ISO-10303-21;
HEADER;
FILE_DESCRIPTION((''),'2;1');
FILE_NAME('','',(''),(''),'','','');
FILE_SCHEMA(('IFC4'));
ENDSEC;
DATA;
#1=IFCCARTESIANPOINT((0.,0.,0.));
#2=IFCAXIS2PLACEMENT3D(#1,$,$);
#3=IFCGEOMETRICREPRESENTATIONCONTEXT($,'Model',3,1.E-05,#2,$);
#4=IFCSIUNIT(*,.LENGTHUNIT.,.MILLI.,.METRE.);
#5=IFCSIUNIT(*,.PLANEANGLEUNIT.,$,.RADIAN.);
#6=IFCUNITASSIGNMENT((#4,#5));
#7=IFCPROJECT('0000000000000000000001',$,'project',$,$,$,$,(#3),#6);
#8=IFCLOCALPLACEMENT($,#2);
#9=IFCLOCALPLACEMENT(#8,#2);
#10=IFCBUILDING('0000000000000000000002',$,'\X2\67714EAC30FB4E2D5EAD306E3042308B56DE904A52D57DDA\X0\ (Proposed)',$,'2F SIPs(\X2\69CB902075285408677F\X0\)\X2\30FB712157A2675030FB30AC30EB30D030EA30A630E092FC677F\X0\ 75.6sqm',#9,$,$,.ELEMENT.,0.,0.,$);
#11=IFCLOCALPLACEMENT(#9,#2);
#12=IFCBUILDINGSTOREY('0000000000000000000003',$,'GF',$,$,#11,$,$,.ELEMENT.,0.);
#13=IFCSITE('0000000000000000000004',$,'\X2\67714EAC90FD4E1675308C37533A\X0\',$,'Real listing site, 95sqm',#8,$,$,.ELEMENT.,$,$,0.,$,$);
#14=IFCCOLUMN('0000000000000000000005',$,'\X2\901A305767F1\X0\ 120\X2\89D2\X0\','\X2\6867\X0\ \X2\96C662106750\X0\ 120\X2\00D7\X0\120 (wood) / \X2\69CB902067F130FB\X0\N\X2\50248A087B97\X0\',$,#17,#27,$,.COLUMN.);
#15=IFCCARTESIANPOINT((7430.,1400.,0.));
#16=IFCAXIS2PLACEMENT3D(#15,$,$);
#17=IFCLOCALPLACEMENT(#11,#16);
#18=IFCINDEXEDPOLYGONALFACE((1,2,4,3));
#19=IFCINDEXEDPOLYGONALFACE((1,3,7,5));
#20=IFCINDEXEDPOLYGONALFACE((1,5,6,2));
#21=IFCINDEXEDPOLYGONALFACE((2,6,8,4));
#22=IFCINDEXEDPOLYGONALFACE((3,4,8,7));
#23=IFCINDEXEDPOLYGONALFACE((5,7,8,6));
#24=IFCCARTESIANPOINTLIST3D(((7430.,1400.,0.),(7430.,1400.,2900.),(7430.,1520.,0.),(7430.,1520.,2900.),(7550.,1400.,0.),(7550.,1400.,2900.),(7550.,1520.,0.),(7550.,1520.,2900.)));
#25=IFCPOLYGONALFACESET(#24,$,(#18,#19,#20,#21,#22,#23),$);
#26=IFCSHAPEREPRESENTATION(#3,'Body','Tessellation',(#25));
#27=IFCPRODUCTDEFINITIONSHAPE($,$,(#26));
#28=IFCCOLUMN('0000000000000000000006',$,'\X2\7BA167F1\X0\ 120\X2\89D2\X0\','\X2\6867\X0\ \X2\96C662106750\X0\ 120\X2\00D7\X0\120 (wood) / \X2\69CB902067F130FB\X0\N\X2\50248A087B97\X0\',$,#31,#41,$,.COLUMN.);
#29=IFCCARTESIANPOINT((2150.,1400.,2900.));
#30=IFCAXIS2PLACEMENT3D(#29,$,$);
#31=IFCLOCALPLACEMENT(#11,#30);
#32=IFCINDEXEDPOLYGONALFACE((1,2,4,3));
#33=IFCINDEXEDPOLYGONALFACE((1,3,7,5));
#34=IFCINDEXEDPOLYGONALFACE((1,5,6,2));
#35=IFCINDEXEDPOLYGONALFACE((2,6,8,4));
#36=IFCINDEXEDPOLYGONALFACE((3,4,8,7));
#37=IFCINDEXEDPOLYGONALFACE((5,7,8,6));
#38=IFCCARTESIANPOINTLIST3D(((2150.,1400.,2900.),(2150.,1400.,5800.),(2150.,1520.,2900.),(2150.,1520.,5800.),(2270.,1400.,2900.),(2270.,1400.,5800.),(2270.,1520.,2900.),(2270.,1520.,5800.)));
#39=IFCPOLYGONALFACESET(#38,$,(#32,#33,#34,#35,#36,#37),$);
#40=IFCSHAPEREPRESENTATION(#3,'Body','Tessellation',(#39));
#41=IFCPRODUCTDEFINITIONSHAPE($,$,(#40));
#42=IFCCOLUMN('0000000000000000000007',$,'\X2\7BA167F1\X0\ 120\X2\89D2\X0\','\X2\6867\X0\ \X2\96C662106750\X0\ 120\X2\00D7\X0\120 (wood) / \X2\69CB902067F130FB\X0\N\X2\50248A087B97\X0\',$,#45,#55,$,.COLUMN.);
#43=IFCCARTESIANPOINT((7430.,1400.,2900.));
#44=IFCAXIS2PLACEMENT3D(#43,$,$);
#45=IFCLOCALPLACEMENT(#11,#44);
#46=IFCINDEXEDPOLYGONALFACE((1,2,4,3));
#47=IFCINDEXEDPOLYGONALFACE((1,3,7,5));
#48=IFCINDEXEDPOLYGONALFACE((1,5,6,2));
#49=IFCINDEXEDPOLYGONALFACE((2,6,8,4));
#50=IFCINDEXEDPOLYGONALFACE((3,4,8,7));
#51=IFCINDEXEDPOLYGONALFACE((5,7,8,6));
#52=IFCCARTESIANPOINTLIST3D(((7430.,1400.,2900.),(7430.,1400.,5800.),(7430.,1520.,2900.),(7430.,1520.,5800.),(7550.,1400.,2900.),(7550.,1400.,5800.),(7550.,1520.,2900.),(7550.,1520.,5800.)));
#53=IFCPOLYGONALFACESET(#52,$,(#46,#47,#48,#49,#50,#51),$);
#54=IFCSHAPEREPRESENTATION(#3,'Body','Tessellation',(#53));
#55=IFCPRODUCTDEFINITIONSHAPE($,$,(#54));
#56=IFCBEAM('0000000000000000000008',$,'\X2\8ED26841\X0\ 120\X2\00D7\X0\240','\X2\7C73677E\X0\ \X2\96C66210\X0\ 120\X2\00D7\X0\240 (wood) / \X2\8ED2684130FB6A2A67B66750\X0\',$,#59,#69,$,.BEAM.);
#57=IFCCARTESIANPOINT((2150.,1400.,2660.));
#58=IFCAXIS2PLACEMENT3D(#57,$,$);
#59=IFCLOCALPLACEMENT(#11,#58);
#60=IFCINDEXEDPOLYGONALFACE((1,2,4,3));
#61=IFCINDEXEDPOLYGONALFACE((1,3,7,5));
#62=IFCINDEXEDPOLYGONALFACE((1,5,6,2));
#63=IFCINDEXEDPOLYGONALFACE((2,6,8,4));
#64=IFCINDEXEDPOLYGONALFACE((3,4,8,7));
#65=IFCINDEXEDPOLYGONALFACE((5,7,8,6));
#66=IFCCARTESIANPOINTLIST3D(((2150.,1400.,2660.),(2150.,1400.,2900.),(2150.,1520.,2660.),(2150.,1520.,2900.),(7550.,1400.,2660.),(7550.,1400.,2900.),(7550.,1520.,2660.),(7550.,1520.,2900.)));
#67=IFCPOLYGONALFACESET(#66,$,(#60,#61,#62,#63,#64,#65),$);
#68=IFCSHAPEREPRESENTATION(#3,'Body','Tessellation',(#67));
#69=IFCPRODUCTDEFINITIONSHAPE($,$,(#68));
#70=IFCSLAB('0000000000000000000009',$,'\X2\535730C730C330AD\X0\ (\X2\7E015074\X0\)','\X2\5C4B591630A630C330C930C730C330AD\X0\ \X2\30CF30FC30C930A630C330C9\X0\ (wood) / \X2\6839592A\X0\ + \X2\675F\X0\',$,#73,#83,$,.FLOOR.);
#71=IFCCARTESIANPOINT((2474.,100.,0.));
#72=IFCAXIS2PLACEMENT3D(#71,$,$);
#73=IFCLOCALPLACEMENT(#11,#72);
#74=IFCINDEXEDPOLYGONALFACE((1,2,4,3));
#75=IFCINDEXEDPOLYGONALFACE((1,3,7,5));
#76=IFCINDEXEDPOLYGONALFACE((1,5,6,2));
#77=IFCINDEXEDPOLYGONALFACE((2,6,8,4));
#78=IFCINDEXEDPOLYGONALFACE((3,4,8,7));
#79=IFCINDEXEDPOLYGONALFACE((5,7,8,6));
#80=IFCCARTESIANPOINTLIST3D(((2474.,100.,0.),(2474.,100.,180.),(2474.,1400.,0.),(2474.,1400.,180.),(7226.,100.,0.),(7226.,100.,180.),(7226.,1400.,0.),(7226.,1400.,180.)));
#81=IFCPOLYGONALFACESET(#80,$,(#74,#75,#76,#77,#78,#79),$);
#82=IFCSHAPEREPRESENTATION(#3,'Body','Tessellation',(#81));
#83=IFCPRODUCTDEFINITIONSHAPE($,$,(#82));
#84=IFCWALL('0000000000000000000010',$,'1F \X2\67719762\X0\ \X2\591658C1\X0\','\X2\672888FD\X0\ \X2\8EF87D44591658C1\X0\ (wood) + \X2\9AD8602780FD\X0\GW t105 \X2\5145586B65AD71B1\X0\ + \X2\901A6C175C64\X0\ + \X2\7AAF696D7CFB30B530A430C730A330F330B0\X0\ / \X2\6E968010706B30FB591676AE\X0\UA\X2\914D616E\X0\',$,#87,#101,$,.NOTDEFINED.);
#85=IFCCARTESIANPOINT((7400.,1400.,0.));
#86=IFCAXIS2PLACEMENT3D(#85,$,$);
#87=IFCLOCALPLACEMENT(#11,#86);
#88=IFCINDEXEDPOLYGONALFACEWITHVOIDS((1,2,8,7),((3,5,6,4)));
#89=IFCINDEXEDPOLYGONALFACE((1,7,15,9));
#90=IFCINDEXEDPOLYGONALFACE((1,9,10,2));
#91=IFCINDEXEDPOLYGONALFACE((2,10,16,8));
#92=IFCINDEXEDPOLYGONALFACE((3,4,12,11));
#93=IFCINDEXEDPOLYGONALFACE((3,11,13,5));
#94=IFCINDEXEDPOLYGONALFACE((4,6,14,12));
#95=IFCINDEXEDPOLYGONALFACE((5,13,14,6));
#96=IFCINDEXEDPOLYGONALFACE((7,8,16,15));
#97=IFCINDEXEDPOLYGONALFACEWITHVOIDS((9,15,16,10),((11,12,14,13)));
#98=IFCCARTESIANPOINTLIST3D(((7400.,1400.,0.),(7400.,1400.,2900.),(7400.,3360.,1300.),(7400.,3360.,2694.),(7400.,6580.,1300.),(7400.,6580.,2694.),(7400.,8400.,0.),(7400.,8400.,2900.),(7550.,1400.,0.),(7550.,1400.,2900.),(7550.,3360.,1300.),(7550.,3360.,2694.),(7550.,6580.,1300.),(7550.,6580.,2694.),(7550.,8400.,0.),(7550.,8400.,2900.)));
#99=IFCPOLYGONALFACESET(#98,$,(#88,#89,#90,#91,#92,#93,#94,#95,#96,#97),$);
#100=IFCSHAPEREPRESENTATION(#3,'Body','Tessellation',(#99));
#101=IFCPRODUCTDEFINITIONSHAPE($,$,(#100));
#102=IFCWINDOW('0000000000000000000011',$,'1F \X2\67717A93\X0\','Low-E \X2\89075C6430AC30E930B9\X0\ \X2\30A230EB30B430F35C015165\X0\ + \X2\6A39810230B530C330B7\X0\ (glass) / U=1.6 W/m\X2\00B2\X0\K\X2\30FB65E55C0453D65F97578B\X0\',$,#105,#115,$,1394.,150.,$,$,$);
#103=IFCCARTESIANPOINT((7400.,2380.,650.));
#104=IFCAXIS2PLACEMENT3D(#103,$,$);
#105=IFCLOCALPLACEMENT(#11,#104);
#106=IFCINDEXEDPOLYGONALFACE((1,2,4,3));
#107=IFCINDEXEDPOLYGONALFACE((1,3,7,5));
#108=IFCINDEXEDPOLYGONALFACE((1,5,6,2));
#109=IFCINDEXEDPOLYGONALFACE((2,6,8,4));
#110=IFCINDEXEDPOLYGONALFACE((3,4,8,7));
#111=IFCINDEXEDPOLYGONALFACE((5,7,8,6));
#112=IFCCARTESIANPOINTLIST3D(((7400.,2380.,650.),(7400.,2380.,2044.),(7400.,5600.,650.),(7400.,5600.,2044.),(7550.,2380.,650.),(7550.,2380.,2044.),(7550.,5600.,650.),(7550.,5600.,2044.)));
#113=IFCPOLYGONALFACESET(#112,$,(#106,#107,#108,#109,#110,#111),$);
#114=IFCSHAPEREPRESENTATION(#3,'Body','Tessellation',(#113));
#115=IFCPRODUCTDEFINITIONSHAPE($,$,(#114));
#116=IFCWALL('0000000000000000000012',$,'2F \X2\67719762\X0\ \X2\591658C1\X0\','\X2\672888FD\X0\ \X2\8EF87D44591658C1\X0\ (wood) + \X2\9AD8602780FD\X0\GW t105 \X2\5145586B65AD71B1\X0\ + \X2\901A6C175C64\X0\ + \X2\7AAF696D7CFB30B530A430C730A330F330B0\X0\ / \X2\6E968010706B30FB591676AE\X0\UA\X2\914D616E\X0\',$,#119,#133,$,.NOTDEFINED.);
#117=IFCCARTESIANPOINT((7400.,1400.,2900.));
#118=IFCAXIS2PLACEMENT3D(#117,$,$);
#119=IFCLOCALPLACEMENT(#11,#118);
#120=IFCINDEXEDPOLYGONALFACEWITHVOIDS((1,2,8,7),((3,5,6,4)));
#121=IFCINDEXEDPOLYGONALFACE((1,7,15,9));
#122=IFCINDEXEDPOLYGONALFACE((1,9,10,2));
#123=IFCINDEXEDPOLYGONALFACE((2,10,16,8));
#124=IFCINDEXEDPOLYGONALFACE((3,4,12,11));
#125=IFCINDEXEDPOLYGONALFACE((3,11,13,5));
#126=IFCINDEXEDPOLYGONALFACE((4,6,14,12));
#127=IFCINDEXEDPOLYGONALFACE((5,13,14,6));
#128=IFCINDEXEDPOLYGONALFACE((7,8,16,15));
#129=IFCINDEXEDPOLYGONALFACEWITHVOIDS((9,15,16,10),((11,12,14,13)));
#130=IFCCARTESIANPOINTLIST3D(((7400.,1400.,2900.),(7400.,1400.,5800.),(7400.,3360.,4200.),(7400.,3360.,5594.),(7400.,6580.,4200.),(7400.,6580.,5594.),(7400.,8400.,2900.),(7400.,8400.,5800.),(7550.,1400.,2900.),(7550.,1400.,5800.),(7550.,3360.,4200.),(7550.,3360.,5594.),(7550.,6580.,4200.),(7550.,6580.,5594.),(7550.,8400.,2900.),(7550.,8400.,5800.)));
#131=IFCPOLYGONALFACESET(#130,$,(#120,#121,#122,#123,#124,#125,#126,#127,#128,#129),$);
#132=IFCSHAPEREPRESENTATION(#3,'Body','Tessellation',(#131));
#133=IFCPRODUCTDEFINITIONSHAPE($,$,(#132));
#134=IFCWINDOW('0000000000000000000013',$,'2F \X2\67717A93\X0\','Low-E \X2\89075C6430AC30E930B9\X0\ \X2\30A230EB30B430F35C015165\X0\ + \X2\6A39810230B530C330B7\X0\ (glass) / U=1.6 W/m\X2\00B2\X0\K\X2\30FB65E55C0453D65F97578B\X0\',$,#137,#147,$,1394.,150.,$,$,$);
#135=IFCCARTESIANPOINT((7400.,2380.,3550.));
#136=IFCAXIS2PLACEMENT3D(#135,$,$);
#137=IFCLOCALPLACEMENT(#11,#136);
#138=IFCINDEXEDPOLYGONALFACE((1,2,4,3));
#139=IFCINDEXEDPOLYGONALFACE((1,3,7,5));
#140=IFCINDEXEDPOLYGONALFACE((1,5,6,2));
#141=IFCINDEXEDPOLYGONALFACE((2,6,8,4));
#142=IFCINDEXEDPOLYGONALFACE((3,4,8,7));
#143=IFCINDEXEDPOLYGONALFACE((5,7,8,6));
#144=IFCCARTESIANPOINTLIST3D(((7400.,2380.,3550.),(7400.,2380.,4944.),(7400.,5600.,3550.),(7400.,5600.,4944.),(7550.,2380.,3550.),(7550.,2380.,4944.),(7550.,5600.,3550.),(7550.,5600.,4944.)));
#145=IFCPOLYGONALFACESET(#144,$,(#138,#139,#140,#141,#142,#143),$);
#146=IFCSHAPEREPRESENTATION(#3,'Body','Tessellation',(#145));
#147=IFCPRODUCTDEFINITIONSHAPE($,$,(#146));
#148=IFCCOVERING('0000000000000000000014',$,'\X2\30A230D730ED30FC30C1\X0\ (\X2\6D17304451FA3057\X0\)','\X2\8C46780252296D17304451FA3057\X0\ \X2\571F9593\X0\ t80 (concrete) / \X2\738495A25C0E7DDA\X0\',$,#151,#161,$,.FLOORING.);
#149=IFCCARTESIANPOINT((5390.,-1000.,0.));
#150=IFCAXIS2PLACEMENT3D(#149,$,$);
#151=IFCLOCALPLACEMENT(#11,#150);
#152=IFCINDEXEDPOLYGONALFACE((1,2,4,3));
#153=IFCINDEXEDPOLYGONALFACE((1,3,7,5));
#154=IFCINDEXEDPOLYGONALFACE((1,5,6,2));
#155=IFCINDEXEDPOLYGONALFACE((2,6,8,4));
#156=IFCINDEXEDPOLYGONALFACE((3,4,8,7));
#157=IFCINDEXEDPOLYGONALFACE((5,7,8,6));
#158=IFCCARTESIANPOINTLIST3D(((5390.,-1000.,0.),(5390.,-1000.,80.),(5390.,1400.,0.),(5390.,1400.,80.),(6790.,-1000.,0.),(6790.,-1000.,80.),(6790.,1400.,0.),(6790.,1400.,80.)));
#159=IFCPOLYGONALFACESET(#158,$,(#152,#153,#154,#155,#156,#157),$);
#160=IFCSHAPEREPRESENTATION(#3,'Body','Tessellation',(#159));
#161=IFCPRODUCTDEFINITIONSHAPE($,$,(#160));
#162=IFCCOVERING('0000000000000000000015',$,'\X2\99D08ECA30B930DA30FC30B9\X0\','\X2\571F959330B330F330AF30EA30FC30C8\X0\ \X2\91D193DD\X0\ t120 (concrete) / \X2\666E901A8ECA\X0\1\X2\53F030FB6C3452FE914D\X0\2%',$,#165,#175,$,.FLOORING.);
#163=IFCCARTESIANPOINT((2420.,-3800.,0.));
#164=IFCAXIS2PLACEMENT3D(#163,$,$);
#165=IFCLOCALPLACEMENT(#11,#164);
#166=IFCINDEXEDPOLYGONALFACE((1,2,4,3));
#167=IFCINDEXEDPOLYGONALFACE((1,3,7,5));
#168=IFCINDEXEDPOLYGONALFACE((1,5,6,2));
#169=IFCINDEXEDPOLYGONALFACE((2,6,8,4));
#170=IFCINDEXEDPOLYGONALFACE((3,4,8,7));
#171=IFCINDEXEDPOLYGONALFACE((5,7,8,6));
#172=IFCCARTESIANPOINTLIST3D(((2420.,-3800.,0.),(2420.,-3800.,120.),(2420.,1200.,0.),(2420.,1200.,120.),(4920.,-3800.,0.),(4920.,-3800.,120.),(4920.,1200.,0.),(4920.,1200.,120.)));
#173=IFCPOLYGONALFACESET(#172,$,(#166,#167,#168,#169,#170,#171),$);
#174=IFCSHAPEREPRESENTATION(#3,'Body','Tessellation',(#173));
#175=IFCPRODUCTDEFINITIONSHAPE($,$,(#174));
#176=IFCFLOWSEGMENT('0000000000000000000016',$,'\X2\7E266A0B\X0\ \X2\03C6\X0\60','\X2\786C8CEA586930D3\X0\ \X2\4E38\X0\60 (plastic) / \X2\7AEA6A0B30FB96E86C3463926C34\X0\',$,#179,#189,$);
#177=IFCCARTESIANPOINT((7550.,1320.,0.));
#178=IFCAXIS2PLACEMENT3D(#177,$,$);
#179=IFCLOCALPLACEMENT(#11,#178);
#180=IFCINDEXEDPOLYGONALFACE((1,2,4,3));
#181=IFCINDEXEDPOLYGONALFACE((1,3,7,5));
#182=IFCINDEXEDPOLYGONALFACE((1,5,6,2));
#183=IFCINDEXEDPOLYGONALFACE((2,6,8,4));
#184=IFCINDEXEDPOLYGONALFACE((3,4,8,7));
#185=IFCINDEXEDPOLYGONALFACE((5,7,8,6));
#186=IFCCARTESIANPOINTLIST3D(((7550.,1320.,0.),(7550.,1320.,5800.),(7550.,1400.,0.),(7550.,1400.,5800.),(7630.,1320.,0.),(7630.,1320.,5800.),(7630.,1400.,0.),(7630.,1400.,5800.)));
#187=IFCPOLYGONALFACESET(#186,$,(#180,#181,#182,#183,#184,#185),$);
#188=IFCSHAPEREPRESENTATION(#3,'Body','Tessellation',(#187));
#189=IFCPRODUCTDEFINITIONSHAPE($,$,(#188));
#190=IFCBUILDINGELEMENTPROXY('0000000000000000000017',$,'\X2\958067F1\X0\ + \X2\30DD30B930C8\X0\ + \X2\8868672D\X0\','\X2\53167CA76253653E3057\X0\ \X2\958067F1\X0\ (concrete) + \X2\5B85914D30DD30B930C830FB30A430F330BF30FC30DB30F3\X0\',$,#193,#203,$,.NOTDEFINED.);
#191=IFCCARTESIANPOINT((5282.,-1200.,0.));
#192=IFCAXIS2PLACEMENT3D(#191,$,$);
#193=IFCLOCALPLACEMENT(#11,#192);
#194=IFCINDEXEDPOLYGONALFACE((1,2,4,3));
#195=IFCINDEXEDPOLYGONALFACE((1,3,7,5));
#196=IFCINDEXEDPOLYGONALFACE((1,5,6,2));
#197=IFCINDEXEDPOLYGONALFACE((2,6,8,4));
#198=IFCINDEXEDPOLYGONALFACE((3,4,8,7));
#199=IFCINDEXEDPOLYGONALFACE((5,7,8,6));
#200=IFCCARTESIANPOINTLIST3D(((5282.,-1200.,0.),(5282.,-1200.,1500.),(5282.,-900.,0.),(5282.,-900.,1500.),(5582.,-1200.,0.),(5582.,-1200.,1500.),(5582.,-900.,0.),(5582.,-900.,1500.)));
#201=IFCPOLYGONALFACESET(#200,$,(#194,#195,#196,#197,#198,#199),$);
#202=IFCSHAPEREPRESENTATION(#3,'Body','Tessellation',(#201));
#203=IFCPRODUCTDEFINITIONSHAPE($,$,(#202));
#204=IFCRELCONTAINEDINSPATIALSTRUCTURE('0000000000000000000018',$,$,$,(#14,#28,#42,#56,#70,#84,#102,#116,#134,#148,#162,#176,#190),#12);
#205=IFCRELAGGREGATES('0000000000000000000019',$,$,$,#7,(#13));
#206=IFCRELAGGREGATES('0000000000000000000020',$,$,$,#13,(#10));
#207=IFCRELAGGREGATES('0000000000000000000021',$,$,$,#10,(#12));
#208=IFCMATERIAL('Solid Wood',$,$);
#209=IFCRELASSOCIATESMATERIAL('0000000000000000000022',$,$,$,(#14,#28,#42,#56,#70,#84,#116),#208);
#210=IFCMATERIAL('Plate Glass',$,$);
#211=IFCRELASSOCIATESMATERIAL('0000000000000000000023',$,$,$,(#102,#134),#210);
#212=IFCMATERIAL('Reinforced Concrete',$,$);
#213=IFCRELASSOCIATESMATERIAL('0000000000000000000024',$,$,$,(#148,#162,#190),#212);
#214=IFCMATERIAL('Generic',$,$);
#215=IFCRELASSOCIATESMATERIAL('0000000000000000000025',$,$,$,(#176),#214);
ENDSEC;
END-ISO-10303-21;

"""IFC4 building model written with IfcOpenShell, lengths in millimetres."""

from ifc_helpers import new_model, si_unit, frame, frame_2d, origin, place, context, project, spatial, rectangle, extrude, material, element, fill, save


model = new_model("IFC4")

# Units and contexts
model_context = context("Model", 3, precision=1e-05, world=origin())
ifc_project = project(units=[si_unit("LENGTHUNIT", "METRE", prefix="MILLI"), si_unit("PLANEANGLEUNIT", "RADIAN")], contexts=[model_context])

# Site, building, storey
site_placement = place(None, origin())
site = spatial("IfcSite", under=ifc_project, at=site_placement, Name="東京都世田谷区", ObjectType="Real listing site, 95sqm", CompositionType="ELEMENT", RefElevation=0.0)
building_placement = place(site_placement, origin())
building = spatial("IfcBuilding", under=site, at=building_placement, Name="東京・中庭のある回遊動線 (Proposed)", ObjectType="2F SIPs(構造用合板)・無垢材・ガルバリウム鋼板 75.6sqm", CompositionType="ELEMENT", ElevationOfRefHeight=0.0, ElevationOfTerrain=0.0)
storey_placement = place(building_placement, origin())
storey = spatial("IfcBuildingStorey", under=building, at=storey_placement, Name="GF", CompositionType="ELEMENT", Elevation=0.0)

# Columns
ifc_material_1 = material(Name="Solid Wood")
column_1_placement = place(storey_placement, frame((7430.0, 1400.0, 0.0)))
element("IfcColumn", 1, at=column_1_placement, inside=storey, material=ifc_material_1, Name="通し柱 120角", Description="桧 集成材 120×120 (wood) / 構造柱・N値計算", PredefinedType="COLUMN", context=model_context, shape_type="SweptSolid", body=[
    extrude(rectangle(XDim=120.0, YDim=120.0, at=frame_2d((60.0, 60.0))), frame((7430.0, 1400.0, 0.0)), (0.0, 0.0, 1.0), 2900.0),
])
column_2_placement = place(storey_placement, frame((2150.0, 1400.0, 2900.0)))
element("IfcColumn", 2, at=column_2_placement, inside=storey, material=ifc_material_1, Name="管柱 120角", Description="桧 集成材 120×120 (wood) / 構造柱・N値計算", PredefinedType="COLUMN", context=model_context, shape_type="SweptSolid", body=[
    extrude(rectangle(XDim=120.0, YDim=120.0, at=frame_2d((60.0, 60.0))), frame((2150.0, 1400.0, 2900.0)), (0.0, 0.0, 1.0), 2900.0),
])
column_3_placement = place(storey_placement, frame((7430.0, 1400.0, 2900.0)))
element("IfcColumn", 3, at=column_3_placement, inside=storey, material=ifc_material_1, Name="管柱 120角", Description="桧 集成材 120×120 (wood) / 構造柱・N値計算", PredefinedType="COLUMN", context=model_context, shape_type="SweptSolid", body=[
    extrude(rectangle(XDim=120.0, YDim=120.0, at=frame_2d((60.0, 60.0))), frame((7430.0, 1400.0, 2900.0)), (0.0, 0.0, 1.0), 2900.0),
])

# Beam
beam_1_placement = place(storey_placement, frame((2150.0, 1400.0, 2660.0)))
element("IfcBeam", 4, at=beam_1_placement, inside=storey, material=ifc_material_1, Name="軒桁 120×240", Description="米松 集成 120×240 (wood) / 軒桁・横架材", PredefinedType="BEAM", context=model_context, shape_type="SweptSolid", body=[
    extrude(rectangle(XDim=5400.0, YDim=120.0, at=frame_2d((2700.0, 60.0))), frame((2150.0, 1400.0, 2660.0)), (0.0, 0.0, 1.0), 240.0),
])

# Slab
slab_placement = place(storey_placement, frame((2474.0, 100.0, 0.0)))
element("IfcSlab", 5, at=slab_placement, inside=storey, material=ifc_material_1, Name="南デッキ (縁側)", Description="屋外ウッドデッキ ハードウッド (wood) / 根太 + 束", PredefinedType="FLOOR", context=model_context, shape_type="SweptSolid", body=[
    extrude(rectangle(XDim=4752.0, YDim=1300.0, at=frame_2d((2376.0, 650.0))), frame((2474.0, 100.0, 0.0)), (0.0, 0.0, 1.0), 180.0),
])

# Walls, openings, windows
wall_1_placement = place(storey_placement, frame((7400.0, 1400.0, 0.0)))
wall_1 = element("IfcWall", 6, at=wall_1_placement, inside=storey, material=ifc_material_1, Name="1F 東面 外壁", Description="木製 軸組外壁 (wood) + 高性能GW t105 充填断熱 + 通気層 + 窯業系サイディング / 準耐火・外皮UA配慮", PredefinedType="NOTDEFINED", context=model_context, shape_type="SweptSolid", body=[
    extrude(rectangle(XDim=150.0, YDim=7000.0, at=frame_2d((75.0, 3500.0))), frame((7400.0, 1400.0, 0.0)), (0.0, 0.0, 1.0), 2900.0),
])
opening_1_placement = place(storey_placement, frame((7400.0, 2380.0, 650.0)))
opening_1 = element("IfcOpeningElement", 7, at=opening_1_placement, cuts=wall_1, PredefinedType="NOTDEFINED", context=model_context, shape_type="SweptSolid", body=[
    extrude(rectangle(XDim=150.0, YDim=3220.0, at=frame_2d((75.0, 1610.0))), frame((7400.0, 2380.0, 650.0)), (0.0, 0.0, 1.0), 1394.0),
])
ifc_material_2 = material(Name="Plate Glass")
window_1_placement = place(storey_placement, frame((7400.0, 2380.0, 650.0)))
window_1 = element("IfcWindow", 8, at=window_1_placement, inside=storey, material=ifc_material_2, Name="1F 東窓", Description="Low-E 複層ガラス アルゴン封入 + 樹脂サッシ (glass) / U=1.6 W/m²K・日射取得型", OverallHeight=1394.0, OverallWidth=150.0, context=model_context, shape_type="SweptSolid", body=[
    extrude(rectangle(XDim=150.0, YDim=3220.0, at=frame_2d((75.0, 1610.0))), frame((7400.0, 2380.0, 650.0)), (0.0, 0.0, 1.0), 1394.0),
])
fill(opening_1, window_1)
wall_2_placement = place(storey_placement, frame((7400.0, 1400.0, 2900.0)))
wall_2 = element("IfcWall", 9, at=wall_2_placement, inside=storey, material=ifc_material_1, Name="2F 東面 外壁", Description="木製 軸組外壁 (wood) + 高性能GW t105 充填断熱 + 通気層 + 窯業系サイディング / 準耐火・外皮UA配慮", PredefinedType="NOTDEFINED", context=model_context, shape_type="SweptSolid", body=[
    extrude(rectangle(XDim=150.0, YDim=7000.0, at=frame_2d((75.0, 3500.0))), frame((7400.0, 1400.0, 2900.0)), (0.0, 0.0, 1.0), 2900.0),
])
opening_2_placement = place(storey_placement, frame((7400.0, 2380.0, 3550.0)))
opening_2 = element("IfcOpeningElement", 10, at=opening_2_placement, cuts=wall_2, PredefinedType="NOTDEFINED", context=model_context, shape_type="SweptSolid", body=[
    extrude(rectangle(XDim=150.0, YDim=3220.0, at=frame_2d((75.0, 1610.0))), frame((7400.0, 2380.0, 3550.0)), (0.0, 0.0, 1.0), 1394.0),
])
window_2_placement = place(storey_placement, frame((7400.0, 2380.0, 3550.0)))
window_2 = element("IfcWindow", 11, at=window_2_placement, inside=storey, material=ifc_material_2, Name="2F 東窓", Description="Low-E 複層ガラス アルゴン封入 + 樹脂サッシ (glass) / U=1.6 W/m²K・日射取得型", OverallHeight=1394.0, OverallWidth=150.0, context=model_context, shape_type="SweptSolid", body=[
    extrude(rectangle(XDim=150.0, YDim=3220.0, at=frame_2d((75.0, 1610.0))), frame((7400.0, 2380.0, 3550.0)), (0.0, 0.0, 1.0), 1394.0),
])
fill(opening_2, window_2)

# Coverings
ifc_material_3 = material(Name="Reinforced Concrete")
covering_1_placement = place(storey_placement, frame((5390.0, -1000.0, 0.0)))
element("IfcCovering", 12, at=covering_1_placement, inside=storey, material=ifc_material_3, Name="アプローチ (洗い出し)", Description="豆砂利洗い出し 土間 t80 (concrete) / 玄関導線", PredefinedType="FLOORING", context=model_context, shape_type="SweptSolid", body=[
    extrude(rectangle(XDim=1400.0, YDim=2400.0, at=frame_2d((700.0, 1200.0))), frame((5390.0, -1000.0, 0.0)), (0.0, 0.0, 1.0), 80.0),
])
covering_2_placement = place(storey_placement, frame((2420.0, -3800.0, 0.0)))
element("IfcCovering", 13, at=covering_2_placement, inside=storey, material=ifc_material_3, Name="駐車スペース", Description="土間コンクリート 金鏝 t120 (concrete) / 普通車1台・水勾配2%", PredefinedType="FLOORING", context=model_context, shape_type="SweptSolid", body=[
    extrude(rectangle(XDim=2500.0, YDim=5000.0, at=frame_2d((1250.0, 2500.0))), frame((2420.0, -3800.0, 0.0)), (0.0, 0.0, 1.0), 120.0),
])

# Flow segment
ifc_material_4 = material(Name="Generic")
flow_segment_placement = place(storey_placement, frame((7550.0, 1320.0, 0.0)))
element("IfcFlowSegment", 14, at=flow_segment_placement, inside=storey, material=ifc_material_4, Name="縦樋 φ60", Description="硬質塩ビ 丸60 (plastic) / 竪樋・雨水排水", context=model_context, shape_type="SweptSolid", body=[
    extrude(rectangle(XDim=80.0, YDim=80.0, at=frame_2d((40.0, 40.0))), frame((7550.0, 1320.0, 0.0)), (0.0, 0.0, 1.0), 5800.0),
])

# Building element proxy
proxy_placement = place(storey_placement, frame((5282.0, -1200.0, 0.0)))
element("IfcBuildingElementProxy", 15, at=proxy_placement, inside=storey, material=ifc_material_3, Name="門柱 + ポスト + 表札", Description="化粧打放し 門柱 (concrete) + 宅配ポスト・インターホン", PredefinedType="NOTDEFINED", context=model_context, shape_type="SweptSolid", body=[
    extrude(rectangle(XDim=300.0, YDim=300.0, at=frame_2d((150.0, 150.0))), frame((5282.0, -1200.0, 0.0)), (0.0, 0.0, 1.0), 1500.0),
])

save(model, "model.ifc")
